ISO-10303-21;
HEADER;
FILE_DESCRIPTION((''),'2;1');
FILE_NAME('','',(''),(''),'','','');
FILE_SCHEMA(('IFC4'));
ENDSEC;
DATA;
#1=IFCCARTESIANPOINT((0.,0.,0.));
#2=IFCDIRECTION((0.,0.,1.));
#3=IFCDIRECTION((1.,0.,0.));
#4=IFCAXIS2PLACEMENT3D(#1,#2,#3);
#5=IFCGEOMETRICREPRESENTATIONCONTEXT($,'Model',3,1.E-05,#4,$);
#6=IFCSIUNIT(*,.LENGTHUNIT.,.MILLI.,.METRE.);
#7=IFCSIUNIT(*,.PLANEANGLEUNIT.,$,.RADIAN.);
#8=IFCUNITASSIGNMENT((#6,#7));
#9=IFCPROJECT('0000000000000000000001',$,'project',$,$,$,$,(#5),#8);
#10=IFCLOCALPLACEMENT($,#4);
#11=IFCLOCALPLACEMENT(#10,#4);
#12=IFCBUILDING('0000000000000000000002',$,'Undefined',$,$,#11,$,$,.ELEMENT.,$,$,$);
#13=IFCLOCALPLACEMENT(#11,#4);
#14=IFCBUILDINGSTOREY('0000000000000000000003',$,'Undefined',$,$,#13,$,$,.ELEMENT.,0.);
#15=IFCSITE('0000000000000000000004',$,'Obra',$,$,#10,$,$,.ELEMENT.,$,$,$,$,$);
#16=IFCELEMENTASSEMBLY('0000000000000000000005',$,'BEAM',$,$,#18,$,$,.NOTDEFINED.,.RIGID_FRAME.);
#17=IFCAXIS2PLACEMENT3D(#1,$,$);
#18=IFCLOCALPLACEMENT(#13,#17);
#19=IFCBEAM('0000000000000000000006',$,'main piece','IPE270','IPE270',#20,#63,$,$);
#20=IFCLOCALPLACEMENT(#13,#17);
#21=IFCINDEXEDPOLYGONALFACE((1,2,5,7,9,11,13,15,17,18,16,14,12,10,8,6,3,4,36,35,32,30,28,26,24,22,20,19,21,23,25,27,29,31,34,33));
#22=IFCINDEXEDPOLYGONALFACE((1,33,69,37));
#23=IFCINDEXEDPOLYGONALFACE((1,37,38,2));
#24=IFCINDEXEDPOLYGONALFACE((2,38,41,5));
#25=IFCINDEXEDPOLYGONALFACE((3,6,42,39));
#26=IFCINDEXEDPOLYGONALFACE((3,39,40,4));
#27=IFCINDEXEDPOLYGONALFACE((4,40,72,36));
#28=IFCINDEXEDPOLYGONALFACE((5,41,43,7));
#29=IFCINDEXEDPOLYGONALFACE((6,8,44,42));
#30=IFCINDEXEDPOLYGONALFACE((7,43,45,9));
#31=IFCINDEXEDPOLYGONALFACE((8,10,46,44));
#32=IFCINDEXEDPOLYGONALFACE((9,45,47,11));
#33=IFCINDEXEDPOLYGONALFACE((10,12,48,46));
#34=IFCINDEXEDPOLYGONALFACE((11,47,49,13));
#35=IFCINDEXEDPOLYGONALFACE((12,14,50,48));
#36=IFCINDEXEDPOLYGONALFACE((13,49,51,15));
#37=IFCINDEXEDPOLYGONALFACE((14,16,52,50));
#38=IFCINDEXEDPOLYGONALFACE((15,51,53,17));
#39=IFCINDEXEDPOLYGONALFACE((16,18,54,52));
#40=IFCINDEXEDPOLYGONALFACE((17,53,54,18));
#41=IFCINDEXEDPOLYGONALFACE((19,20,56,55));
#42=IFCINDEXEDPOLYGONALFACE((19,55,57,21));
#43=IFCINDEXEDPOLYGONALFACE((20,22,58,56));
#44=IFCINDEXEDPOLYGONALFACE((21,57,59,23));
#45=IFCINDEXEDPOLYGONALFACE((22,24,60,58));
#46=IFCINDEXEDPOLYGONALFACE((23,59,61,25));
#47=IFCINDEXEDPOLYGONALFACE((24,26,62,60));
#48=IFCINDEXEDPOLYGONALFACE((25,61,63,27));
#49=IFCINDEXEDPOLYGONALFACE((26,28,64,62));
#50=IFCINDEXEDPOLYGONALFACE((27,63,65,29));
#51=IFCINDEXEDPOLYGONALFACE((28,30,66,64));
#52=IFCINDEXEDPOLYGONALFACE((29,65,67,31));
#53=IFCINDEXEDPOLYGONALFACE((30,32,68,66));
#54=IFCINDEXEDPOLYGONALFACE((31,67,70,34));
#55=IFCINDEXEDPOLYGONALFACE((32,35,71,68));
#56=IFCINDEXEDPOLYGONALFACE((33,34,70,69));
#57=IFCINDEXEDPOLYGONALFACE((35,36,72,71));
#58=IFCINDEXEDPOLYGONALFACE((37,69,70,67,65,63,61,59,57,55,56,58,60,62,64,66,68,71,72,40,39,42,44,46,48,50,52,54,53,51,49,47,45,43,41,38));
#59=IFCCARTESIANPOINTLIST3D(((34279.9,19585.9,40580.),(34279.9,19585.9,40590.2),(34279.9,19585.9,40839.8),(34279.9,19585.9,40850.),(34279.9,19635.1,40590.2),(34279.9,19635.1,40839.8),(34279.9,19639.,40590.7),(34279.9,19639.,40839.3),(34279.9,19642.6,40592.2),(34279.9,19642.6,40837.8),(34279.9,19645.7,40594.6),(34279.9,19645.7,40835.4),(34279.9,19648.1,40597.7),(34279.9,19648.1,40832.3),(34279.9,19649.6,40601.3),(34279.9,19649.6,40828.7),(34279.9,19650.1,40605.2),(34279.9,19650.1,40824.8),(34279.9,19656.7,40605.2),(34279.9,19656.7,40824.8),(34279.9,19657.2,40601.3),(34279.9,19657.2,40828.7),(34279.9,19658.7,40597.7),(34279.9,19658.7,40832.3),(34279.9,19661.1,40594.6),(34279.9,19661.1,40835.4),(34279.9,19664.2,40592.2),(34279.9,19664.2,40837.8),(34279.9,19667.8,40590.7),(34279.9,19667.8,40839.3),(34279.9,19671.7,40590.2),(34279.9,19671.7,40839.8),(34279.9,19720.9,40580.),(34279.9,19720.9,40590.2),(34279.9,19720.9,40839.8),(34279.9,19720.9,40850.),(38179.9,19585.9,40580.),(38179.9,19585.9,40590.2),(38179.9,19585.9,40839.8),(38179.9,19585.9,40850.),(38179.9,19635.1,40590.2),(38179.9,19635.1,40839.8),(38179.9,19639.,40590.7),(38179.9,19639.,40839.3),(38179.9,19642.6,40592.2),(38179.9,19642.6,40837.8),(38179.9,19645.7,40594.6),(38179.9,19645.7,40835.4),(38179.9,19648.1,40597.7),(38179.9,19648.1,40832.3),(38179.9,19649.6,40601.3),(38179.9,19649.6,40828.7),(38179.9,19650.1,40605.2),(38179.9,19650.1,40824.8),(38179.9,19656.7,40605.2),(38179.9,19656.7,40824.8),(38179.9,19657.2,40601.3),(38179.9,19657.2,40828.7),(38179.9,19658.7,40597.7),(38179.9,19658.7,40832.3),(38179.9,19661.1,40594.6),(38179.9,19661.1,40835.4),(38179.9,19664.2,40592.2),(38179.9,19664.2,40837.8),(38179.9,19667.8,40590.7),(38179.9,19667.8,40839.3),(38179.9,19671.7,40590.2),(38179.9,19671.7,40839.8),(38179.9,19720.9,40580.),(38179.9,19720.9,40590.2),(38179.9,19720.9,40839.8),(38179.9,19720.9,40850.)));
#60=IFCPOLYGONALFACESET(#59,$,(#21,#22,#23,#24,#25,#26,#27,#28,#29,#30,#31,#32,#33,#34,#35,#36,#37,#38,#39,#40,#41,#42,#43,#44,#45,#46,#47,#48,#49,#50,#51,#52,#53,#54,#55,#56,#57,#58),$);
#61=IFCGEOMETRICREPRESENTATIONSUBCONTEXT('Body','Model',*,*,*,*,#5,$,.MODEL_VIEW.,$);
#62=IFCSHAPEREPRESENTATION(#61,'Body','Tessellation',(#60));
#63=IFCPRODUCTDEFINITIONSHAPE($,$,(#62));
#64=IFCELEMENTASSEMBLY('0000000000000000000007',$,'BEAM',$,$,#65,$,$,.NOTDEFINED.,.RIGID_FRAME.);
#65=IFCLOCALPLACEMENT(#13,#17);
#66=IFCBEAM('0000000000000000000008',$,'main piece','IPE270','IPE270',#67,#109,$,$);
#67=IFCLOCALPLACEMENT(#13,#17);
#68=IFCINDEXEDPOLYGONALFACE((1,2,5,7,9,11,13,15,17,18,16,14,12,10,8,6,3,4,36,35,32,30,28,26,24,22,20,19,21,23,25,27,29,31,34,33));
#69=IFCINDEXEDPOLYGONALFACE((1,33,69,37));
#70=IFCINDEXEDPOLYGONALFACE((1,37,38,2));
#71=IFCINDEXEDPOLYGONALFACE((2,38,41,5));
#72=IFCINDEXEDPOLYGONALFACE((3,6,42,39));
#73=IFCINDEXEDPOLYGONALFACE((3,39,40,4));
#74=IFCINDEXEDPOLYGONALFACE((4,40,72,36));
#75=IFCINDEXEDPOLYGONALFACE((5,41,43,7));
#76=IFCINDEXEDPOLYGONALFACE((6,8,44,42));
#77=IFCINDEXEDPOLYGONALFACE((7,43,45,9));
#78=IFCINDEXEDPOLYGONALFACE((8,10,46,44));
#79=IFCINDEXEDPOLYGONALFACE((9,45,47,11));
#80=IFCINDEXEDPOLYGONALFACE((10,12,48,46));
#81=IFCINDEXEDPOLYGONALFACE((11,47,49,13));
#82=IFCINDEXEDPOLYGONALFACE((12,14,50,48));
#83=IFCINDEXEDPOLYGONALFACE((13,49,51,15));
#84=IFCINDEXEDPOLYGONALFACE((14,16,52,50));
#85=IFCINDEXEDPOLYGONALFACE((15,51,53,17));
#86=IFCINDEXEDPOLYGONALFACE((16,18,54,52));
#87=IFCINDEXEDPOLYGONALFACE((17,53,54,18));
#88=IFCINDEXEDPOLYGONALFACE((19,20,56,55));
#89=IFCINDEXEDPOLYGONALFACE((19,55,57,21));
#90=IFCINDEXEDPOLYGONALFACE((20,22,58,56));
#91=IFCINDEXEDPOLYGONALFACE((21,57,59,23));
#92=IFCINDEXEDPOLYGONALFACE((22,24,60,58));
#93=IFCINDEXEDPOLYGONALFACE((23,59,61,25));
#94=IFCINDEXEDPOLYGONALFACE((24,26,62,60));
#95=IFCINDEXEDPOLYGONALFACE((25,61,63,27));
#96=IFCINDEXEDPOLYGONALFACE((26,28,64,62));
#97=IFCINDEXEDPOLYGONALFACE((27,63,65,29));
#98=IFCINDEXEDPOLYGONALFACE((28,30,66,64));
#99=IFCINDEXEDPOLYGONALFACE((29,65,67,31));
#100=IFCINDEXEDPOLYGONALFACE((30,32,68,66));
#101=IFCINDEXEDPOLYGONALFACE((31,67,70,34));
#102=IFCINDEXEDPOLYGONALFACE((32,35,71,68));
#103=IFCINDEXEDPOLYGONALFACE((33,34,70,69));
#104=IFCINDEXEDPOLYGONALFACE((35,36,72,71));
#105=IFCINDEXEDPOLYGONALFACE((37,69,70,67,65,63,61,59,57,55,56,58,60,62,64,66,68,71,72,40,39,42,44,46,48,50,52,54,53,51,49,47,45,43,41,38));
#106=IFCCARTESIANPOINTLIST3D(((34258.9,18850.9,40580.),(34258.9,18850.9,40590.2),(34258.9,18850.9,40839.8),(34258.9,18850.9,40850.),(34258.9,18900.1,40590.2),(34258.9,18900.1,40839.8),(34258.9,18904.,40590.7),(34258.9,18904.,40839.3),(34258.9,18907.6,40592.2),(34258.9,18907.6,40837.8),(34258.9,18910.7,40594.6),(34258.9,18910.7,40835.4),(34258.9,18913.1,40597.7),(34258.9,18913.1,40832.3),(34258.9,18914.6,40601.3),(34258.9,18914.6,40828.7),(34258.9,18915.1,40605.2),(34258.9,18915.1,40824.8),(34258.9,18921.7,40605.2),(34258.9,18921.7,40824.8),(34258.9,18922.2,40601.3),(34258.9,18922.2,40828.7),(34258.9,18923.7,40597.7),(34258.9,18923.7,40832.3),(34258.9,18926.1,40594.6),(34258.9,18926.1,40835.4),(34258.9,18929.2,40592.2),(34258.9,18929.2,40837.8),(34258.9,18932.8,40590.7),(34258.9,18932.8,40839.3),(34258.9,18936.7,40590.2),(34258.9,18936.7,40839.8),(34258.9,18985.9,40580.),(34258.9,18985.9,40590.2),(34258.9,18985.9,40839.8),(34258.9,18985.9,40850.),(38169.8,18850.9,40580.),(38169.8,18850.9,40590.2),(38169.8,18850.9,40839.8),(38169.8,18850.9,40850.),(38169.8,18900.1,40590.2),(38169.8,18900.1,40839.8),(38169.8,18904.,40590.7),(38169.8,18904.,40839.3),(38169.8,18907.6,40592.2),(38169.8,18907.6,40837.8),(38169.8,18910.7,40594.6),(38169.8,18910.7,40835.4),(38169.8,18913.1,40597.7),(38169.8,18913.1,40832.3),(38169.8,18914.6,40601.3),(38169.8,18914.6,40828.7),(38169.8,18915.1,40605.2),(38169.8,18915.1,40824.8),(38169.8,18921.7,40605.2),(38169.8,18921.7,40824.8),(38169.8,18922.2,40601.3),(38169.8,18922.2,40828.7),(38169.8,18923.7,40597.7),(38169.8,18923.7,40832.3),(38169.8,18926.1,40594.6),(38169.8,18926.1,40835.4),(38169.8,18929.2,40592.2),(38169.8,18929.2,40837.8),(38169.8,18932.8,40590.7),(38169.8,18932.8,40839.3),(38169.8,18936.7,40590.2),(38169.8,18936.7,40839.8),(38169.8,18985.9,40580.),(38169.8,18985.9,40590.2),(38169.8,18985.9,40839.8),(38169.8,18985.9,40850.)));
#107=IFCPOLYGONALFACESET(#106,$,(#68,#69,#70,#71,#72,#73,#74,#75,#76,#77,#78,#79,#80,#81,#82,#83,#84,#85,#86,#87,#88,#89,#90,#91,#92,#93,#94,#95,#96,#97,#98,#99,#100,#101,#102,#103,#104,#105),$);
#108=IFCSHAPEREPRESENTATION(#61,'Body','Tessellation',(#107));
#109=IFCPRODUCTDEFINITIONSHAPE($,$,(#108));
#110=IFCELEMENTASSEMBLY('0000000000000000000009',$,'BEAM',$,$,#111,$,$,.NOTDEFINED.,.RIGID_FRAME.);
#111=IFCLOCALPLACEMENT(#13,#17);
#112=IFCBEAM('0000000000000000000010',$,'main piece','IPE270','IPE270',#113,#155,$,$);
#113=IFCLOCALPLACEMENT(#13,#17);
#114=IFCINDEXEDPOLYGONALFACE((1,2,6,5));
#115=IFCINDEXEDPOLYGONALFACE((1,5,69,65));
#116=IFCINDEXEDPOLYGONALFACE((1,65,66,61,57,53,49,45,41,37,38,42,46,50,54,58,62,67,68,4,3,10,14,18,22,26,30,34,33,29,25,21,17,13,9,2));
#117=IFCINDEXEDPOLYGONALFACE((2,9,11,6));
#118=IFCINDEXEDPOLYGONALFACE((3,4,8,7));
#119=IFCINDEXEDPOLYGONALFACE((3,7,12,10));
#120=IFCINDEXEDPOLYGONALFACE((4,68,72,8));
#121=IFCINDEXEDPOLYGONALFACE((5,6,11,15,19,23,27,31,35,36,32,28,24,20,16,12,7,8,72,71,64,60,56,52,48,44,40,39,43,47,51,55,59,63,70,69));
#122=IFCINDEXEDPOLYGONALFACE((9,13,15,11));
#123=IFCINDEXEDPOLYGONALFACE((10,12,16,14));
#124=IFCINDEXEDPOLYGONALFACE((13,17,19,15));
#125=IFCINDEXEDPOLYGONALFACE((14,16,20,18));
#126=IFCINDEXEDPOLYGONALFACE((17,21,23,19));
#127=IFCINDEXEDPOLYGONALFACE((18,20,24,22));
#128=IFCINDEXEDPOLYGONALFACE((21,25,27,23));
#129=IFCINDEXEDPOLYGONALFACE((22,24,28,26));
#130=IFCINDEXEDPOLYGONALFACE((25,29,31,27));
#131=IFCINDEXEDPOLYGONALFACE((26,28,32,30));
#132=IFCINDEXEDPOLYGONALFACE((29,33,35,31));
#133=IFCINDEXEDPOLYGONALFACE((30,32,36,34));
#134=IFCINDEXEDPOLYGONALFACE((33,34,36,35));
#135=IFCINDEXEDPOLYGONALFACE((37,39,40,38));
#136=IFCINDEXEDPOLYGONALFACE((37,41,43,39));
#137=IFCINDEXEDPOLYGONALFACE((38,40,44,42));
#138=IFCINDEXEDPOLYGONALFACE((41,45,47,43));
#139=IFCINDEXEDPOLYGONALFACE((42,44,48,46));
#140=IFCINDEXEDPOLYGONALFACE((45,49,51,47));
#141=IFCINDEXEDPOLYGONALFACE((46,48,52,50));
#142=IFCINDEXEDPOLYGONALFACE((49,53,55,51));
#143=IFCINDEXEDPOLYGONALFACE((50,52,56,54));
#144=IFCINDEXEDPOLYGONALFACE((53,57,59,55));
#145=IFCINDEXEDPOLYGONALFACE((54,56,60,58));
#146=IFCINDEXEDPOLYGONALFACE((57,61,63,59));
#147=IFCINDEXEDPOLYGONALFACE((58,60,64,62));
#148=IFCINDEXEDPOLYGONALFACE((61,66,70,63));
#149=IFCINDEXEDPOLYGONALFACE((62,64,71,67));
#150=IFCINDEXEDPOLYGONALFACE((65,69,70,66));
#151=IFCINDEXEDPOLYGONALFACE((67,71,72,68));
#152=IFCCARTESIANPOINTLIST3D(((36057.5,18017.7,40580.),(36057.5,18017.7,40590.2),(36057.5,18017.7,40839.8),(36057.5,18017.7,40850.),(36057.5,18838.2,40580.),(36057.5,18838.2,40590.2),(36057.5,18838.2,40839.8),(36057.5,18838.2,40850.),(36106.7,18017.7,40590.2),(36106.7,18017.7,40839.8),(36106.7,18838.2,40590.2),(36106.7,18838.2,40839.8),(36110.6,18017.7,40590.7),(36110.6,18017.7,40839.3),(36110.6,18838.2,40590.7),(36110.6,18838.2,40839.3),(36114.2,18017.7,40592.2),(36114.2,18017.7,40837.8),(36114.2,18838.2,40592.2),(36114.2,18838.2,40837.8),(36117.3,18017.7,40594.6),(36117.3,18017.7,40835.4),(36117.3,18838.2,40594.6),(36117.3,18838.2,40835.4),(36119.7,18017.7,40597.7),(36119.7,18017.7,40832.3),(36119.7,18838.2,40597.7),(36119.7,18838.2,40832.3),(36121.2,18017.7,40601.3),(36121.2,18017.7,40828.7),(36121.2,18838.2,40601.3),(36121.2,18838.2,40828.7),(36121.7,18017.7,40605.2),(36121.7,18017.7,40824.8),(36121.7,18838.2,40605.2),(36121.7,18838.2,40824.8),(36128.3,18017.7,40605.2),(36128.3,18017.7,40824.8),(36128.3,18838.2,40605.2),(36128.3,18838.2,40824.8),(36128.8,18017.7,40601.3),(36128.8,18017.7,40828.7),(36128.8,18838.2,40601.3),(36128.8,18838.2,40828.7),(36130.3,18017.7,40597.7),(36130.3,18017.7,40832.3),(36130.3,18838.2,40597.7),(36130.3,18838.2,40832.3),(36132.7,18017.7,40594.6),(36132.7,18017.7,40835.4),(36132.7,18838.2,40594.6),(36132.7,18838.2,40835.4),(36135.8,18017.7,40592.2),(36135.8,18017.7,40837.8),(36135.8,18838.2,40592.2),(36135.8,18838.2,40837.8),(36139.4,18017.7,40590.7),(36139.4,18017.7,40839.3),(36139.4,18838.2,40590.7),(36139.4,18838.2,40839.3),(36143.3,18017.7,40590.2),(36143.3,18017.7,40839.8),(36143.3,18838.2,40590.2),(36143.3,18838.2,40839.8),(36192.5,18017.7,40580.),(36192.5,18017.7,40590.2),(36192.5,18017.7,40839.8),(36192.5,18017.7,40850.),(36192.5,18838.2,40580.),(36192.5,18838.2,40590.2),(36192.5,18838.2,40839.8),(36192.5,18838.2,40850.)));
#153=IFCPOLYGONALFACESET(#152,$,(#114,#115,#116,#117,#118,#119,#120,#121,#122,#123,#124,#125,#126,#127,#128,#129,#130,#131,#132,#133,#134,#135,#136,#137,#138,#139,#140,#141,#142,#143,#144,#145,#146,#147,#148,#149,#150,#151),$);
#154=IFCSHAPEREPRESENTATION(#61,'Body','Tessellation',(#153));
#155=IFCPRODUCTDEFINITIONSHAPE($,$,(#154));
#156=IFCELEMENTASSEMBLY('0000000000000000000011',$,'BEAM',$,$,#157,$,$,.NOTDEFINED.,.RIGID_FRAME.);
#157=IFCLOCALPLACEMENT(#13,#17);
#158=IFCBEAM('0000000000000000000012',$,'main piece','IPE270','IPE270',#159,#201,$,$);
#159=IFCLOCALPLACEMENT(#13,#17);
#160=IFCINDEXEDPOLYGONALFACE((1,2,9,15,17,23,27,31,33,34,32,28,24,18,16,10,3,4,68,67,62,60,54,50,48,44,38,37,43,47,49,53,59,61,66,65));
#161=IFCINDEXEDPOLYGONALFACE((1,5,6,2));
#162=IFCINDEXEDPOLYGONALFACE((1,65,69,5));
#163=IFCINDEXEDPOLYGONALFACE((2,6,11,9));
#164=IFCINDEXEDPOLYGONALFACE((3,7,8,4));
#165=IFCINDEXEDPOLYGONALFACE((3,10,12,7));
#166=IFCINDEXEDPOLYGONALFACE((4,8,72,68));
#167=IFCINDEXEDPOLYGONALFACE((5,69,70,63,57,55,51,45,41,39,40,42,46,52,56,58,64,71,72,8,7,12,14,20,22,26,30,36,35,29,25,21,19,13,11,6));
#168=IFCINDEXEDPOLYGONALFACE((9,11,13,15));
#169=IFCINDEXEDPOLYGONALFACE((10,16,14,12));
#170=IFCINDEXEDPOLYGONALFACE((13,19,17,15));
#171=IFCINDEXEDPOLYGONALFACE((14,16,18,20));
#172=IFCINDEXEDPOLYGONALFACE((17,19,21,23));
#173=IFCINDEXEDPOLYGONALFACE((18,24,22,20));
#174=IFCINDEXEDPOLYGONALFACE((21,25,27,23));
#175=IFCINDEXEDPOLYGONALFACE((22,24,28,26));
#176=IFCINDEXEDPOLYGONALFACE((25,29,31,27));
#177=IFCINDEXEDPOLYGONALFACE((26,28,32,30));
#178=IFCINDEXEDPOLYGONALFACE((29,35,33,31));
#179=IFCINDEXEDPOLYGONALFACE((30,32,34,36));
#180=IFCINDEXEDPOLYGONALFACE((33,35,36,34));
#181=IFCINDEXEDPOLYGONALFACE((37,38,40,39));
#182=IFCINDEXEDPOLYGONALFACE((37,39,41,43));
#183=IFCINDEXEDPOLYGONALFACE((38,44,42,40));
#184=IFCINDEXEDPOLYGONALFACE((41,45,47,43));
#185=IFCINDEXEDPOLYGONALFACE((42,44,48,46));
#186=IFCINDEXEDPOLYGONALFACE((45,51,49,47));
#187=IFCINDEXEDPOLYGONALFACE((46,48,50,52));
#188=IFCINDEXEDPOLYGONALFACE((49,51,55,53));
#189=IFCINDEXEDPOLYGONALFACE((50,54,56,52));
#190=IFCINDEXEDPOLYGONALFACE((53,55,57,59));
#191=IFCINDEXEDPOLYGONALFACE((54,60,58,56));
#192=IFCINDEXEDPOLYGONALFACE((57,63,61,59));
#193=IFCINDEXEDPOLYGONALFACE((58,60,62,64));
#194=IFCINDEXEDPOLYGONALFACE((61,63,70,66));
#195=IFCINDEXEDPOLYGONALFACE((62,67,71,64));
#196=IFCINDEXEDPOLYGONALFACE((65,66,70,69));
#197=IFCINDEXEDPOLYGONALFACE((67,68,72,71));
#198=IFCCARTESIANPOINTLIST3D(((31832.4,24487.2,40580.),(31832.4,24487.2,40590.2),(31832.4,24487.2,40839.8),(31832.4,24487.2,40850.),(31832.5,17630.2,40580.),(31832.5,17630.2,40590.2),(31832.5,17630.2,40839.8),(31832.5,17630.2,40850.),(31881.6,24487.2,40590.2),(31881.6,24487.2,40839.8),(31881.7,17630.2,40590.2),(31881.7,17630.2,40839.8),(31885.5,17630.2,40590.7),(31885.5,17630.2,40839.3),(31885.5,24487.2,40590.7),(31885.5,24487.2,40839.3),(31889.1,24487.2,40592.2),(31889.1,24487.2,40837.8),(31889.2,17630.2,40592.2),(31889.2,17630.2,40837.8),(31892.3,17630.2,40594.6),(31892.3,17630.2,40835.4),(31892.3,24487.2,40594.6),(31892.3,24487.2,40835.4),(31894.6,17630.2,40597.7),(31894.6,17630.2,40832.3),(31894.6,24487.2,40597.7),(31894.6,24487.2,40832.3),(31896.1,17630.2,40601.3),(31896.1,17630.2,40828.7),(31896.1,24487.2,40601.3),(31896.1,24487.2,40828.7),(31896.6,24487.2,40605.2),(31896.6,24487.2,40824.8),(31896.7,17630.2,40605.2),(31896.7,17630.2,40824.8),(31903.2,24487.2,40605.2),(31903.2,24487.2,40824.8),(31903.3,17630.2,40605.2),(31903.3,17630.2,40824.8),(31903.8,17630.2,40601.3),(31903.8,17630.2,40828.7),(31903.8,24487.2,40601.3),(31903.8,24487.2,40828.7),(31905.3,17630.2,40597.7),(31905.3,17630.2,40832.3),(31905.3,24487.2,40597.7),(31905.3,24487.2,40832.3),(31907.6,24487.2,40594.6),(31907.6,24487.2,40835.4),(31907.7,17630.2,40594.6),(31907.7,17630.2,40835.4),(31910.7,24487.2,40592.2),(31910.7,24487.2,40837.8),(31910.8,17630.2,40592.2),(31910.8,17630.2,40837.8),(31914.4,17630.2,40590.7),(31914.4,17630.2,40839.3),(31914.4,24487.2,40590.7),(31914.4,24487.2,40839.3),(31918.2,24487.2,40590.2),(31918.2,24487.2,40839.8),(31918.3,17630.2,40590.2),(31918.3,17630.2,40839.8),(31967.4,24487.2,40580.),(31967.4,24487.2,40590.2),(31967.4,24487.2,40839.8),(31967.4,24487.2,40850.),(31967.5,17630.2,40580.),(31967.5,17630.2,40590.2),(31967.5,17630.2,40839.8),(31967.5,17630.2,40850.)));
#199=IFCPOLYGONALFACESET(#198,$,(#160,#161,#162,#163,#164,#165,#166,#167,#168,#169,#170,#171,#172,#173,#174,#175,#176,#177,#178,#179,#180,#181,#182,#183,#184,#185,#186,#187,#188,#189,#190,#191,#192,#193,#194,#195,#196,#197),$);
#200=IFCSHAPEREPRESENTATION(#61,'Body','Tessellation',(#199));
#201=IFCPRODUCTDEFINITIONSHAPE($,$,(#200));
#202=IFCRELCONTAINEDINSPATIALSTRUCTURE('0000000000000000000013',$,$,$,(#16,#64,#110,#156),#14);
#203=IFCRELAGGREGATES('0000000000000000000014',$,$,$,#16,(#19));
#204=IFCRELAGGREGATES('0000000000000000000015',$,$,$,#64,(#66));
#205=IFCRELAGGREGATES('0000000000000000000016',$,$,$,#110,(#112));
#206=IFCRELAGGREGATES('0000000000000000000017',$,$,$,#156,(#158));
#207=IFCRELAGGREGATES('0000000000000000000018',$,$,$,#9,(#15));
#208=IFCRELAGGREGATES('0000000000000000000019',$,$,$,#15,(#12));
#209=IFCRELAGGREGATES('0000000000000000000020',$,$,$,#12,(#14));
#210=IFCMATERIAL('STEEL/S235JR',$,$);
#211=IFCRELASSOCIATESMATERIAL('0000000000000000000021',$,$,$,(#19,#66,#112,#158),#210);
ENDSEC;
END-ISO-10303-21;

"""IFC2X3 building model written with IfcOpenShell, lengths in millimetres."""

from ifc_helpers import new_model, si_unit, frame, origin_with_axes, origin_2d_with_axis, place, context, subcontext, project, spatial, i_section, extrude, material, element, aggregate, save


model = new_model("IFC2X3")

# Units and contexts
model_context = context("Model", 3, precision=1e-05, world=origin_with_axes())
body_context = subcontext(model_context, "Body", "Model", "MODEL_VIEW")
ifc_project = project(units=[si_unit("LENGTHUNIT", "METRE", prefix="MILLI"), si_unit("PLANEANGLEUNIT", "RADIAN")], contexts=[model_context])

# Site, building, storey
site_placement = place(None, origin_with_axes())
site = spatial("IfcSite", under=ifc_project, at=site_placement, Name="Obra", CompositionType="ELEMENT")
building_placement = place(site_placement, origin_with_axes())
building = spatial("IfcBuilding", under=site, at=building_placement, Name="Undefined", CompositionType="ELEMENT")
storey_placement = place(building_placement, origin_with_axes())
storey = spatial("IfcBuildingStorey", under=building, at=storey_placement, Name="Undefined", CompositionType="ELEMENT", Elevation=0.0)

# Element assemblies, beams
ifc_material_1 = material(Name="STEEL/S235JR")
assembly_1_placement = place(storey_placement, origin_with_axes())
assembly_1 = element("IfcElementAssembly", 1, at=assembly_1_placement, inside=storey, Name="BEAM", AssemblyPlace="NOTDEFINED", PredefinedType="RIGID_FRAME")
beam_1_placement = place(assembly_1_placement, frame((34279.9, 19653.4, 40715.0), z_axis=(0.0, 0.0, 1.0), x_axis=(1.0, 0.0, 0.0)))
beam_1 = element("IfcBeam", 2, at=beam_1_placement, material=ifc_material_1, Name="main piece", Description="IPE270", ObjectType="IPE270", context=body_context, shape_type="SweptSolid", body=[
    extrude(i_section(OverallWidth=135.0, OverallDepth=270.0, WebThickness=6.6, FlangeThickness=10.2, FilletRadius=15.0, at=origin_2d_with_axis()), frame((3900.0, 0.0, 0.0), z_axis=(-1.0, 0.0, 0.0), x_axis=(0.0, -1.0, 0.0)), (0.0, 0.0, 1.0), 3900.0),
])
aggregate(assembly_1, [beam_1])
assembly_2_placement = place(storey_placement, origin_with_axes())
assembly_2 = element("IfcElementAssembly", 3, at=assembly_2_placement, inside=storey, Name="BEAM", AssemblyPlace="NOTDEFINED", PredefinedType="RIGID_FRAME")
beam_2_placement = place(assembly_2_placement, frame((34258.9, 18918.4, 40715.0), z_axis=(0.0, 0.0, 1.0), x_axis=(1.0, 0.0, 0.0)))
beam_2 = element("IfcBeam", 4, at=beam_2_placement, material=ifc_material_1, Name="main piece", Description="IPE270", ObjectType="IPE270", context=body_context, shape_type="SweptSolid", body=[
    extrude(i_section(OverallWidth=135.0, OverallDepth=270.0, WebThickness=6.6, FlangeThickness=10.2, FilletRadius=15.0, at=origin_2d_with_axis()), frame((3910.9, 0.0, 0.0), z_axis=(-1.0, 0.0, 0.0), x_axis=(0.0, -1.0, 0.0)), (0.0, 0.0, 1.0), 3910.9),
])
aggregate(assembly_2, [beam_2])
assembly_3_placement = place(storey_placement, origin_with_axes())
assembly_3 = element("IfcElementAssembly", 5, at=assembly_3_placement, inside=storey, Name="BEAM", AssemblyPlace="NOTDEFINED", PredefinedType="RIGID_FRAME")
beam_3_placement = place(assembly_3_placement, frame((36125.0, 18017.7, 40715.0), z_axis=(0.0, 0.0, 1.0), x_axis=(0.0, 1.0, 0.0)))
beam_3 = element("IfcBeam", 6, at=beam_3_placement, material=ifc_material_1, Name="main piece", Description="IPE270", ObjectType="IPE270", context=body_context, shape_type="SweptSolid", body=[
    extrude(i_section(OverallWidth=135.0, OverallDepth=270.0, WebThickness=6.6, FlangeThickness=10.2, FilletRadius=15.0, at=origin_2d_with_axis()), frame((820.5, 0.0, 0.0), z_axis=(-1.0, 0.0, 0.0), x_axis=(0.0, -1.0, 0.0)), (0.0, 0.0, 1.0), 820.5),
])
aggregate(assembly_3, [beam_3])
assembly_4_placement = place(storey_placement, origin_with_axes())
assembly_4 = element("IfcElementAssembly", 7, at=assembly_4_placement, inside=storey, Name="BEAM", AssemblyPlace="NOTDEFINED", PredefinedType="RIGID_FRAME")
beam_4_placement = place(assembly_4_placement, frame((31900.0, 17630.2, 40715.0), z_axis=(0.0, 0.0, 1.0), x_axis=(-0.000002, 1.0, 0.0)))
beam_4 = element("IfcBeam", 8, at=beam_4_placement, material=ifc_material_1, Name="main piece", Description="IPE270", ObjectType="IPE270", context=body_context, shape_type="SweptSolid", body=[
    extrude(i_section(OverallWidth=135.0, OverallDepth=270.0, WebThickness=6.6, FlangeThickness=10.2, FilletRadius=15.0, at=origin_2d_with_axis()), frame((6857.0, 0.0, 0.0), z_axis=(-1.0, 0.0, 0.0), x_axis=(0.0, -1.0, 0.0)), (0.0, 0.0, 1.0), 6857.0),
])
aggregate(assembly_4, [beam_4])

save(model, "model.ifc")
